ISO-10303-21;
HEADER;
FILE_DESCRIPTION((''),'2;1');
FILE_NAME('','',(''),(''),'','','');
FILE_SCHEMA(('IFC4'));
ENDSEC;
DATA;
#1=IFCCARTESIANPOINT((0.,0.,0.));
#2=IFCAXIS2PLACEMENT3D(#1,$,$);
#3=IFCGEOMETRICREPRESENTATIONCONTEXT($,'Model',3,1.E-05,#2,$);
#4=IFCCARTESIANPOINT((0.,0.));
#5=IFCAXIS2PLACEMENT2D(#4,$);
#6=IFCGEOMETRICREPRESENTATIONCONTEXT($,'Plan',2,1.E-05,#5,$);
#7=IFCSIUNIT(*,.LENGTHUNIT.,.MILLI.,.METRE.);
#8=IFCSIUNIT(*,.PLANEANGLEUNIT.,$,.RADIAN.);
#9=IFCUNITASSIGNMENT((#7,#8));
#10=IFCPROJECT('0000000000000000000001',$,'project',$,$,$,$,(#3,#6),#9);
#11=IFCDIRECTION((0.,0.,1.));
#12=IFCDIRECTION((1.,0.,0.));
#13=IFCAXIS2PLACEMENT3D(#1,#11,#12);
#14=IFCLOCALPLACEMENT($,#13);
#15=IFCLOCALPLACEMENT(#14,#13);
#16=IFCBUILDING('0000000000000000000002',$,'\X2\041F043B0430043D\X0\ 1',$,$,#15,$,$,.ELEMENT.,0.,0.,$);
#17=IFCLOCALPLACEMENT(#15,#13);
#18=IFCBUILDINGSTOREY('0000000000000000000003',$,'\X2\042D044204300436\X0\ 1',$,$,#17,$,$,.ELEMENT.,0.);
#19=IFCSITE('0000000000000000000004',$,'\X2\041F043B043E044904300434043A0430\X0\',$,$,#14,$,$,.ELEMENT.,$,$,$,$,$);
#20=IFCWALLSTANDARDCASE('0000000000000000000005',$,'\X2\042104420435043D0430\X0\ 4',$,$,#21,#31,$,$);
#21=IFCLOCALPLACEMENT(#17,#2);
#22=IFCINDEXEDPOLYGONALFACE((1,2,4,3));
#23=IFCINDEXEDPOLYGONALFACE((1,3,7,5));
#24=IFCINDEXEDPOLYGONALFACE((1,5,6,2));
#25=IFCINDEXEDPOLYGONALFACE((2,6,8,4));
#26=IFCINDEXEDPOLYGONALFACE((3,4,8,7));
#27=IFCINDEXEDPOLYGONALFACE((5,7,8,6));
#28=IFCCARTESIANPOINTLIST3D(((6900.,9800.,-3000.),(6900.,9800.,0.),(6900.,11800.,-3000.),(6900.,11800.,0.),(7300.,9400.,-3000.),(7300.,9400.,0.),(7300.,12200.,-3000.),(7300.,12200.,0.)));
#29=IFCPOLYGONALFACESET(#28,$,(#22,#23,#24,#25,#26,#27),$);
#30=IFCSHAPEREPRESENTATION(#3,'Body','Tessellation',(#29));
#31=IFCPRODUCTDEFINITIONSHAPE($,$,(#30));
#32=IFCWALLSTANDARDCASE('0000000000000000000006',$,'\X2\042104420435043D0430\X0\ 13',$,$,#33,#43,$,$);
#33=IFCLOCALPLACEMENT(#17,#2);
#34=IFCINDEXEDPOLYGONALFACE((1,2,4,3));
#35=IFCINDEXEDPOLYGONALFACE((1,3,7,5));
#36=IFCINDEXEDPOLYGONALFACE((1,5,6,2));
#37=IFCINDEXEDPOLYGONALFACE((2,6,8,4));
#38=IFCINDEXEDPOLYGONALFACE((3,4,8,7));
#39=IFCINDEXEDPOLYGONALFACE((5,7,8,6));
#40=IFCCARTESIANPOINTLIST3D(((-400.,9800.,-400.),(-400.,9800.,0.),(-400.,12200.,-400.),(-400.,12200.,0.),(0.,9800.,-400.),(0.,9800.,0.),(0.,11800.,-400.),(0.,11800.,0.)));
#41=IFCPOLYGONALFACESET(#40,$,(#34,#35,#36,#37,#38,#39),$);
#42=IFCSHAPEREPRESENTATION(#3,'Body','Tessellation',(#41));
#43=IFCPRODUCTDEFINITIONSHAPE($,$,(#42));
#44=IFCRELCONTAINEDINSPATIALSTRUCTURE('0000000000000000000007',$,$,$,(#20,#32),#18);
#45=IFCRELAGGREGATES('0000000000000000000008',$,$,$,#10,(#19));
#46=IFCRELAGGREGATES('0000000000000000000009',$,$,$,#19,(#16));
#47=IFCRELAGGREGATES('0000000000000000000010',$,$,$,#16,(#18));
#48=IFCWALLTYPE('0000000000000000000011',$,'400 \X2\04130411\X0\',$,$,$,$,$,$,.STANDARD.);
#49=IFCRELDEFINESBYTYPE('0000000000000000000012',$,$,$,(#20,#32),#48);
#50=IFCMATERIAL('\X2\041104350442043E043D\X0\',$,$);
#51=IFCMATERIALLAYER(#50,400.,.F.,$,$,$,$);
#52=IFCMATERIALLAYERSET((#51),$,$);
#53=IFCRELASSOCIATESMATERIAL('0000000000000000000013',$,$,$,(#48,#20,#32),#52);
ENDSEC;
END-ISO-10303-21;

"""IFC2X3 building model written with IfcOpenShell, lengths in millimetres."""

from ifc_helpers import new_model, si_unit, frame, origin, origin_with_axes, origin_2d, place, context, project, spatial, polyline, segment, composite_curve, outline, extrude, material, layer, layer_set, layer_usage, type_object, element, save


model = new_model("IFC2X3")

# Units and contexts
model_context = context("Model", 3, precision=1e-05, world=origin())
plan_context = context("Plan", 2, precision=1e-05, world=origin_2d())
ifc_project = project(units=[si_unit("LENGTHUNIT", "METRE", prefix="MILLI"), si_unit("PLANEANGLEUNIT", "RADIAN")], contexts=[model_context, plan_context])

# Site, building, storey
site_placement = place(None, origin_with_axes())
site = spatial("IfcSite", under=ifc_project, at=site_placement, Name="Площадка", CompositionType="ELEMENT")
building_placement = place(site_placement, origin_with_axes())
building = spatial("IfcBuilding", under=site, at=building_placement, Name="План 1", CompositionType="ELEMENT", ElevationOfRefHeight=0.0, ElevationOfTerrain=0.0)
storey_placement = place(building_placement, origin_with_axes())
storey = spatial("IfcBuildingStorey", under=building, at=storey_placement, Name="Этаж 1", CompositionType="ELEMENT", Elevation=0.0)

# Walls
ifc_material = material(Name="Бетон")
ifc_layer_1 = layer(ifc_material, 400.0, ventilated=False)
ifc_layer_set_1 = layer_set([ifc_layer_1])
wall_type_1 = type_object("IfcWallType", Name="400 ГБ", PredefinedType="STANDARD", material=ifc_layer_set_1)
ifc_layer_usage_1 = layer_usage(ifc_layer_set_1, "AXIS2", "POSITIVE", 0.0)
wall_1_placement = place(storey_placement, frame((6900.0, 12200.0, -3000.0), z_axis=(0.0, 0.0, 1.0), x_axis=(0.0, -1.0, 0.0)))
element("IfcWallStandardCase", 1, at=wall_1_placement, inside=storey, type_object=wall_type_1, material=ifc_layer_usage_1, Name="Стена 4", context=model_context, shape_type="SweptSolid", body=[
    extrude(outline(composite_curve([segment(polyline([(0.0, 400.0), (400.0, 0.0)]), True, "CONTINUOUS"), segment(polyline([(400.0, 0.0), (2400.0, 0.0)]), True, "CONTINUOUS"), segment(polyline([(2400.0, 0.0), (2800.0, 400.0)]), True, "CONTINUOUS"), segment(polyline([(2800.0, 400.0), (0.0, 400.0)]), True, "CONTINUOUS")], self_intersect=False)), origin_with_axes(), (0.0, 0.0, 1.0), 3000.0),
])
ifc_layer_usage_2 = layer_usage(ifc_layer_set_1, "AXIS2", "POSITIVE", 0.0)
wall_2_placement = place(storey_placement, frame((-400.0, 12200.0, -400.0), z_axis=(0.0, 0.0, 1.0), x_axis=(0.0, -1.0, 0.0)))
element("IfcWallStandardCase", 2, at=wall_2_placement, inside=storey, type_object=wall_type_1, material=ifc_layer_usage_2, Name="Стена 13", context=model_context, shape_type="SweptSolid", body=[
    extrude(outline(composite_curve([segment(polyline([(400.0, 400.0), (0.0, 0.0)]), True, "CONTINUOUS"), segment(polyline([(0.0, 0.0), (2400.0, 0.0)]), True, "CONTINUOUS"), segment(polyline([(2400.0, 0.0), (2400.0, 400.0)]), True, "CONTINUOUS"), segment(polyline([(2400.0, 400.0), (400.0, 400.0)]), True, "CONTINUOUS")], self_intersect=False)), origin_with_axes(), (0.0, 0.0, 1.0), 400.0),
])

save(model, "model.ifc")
